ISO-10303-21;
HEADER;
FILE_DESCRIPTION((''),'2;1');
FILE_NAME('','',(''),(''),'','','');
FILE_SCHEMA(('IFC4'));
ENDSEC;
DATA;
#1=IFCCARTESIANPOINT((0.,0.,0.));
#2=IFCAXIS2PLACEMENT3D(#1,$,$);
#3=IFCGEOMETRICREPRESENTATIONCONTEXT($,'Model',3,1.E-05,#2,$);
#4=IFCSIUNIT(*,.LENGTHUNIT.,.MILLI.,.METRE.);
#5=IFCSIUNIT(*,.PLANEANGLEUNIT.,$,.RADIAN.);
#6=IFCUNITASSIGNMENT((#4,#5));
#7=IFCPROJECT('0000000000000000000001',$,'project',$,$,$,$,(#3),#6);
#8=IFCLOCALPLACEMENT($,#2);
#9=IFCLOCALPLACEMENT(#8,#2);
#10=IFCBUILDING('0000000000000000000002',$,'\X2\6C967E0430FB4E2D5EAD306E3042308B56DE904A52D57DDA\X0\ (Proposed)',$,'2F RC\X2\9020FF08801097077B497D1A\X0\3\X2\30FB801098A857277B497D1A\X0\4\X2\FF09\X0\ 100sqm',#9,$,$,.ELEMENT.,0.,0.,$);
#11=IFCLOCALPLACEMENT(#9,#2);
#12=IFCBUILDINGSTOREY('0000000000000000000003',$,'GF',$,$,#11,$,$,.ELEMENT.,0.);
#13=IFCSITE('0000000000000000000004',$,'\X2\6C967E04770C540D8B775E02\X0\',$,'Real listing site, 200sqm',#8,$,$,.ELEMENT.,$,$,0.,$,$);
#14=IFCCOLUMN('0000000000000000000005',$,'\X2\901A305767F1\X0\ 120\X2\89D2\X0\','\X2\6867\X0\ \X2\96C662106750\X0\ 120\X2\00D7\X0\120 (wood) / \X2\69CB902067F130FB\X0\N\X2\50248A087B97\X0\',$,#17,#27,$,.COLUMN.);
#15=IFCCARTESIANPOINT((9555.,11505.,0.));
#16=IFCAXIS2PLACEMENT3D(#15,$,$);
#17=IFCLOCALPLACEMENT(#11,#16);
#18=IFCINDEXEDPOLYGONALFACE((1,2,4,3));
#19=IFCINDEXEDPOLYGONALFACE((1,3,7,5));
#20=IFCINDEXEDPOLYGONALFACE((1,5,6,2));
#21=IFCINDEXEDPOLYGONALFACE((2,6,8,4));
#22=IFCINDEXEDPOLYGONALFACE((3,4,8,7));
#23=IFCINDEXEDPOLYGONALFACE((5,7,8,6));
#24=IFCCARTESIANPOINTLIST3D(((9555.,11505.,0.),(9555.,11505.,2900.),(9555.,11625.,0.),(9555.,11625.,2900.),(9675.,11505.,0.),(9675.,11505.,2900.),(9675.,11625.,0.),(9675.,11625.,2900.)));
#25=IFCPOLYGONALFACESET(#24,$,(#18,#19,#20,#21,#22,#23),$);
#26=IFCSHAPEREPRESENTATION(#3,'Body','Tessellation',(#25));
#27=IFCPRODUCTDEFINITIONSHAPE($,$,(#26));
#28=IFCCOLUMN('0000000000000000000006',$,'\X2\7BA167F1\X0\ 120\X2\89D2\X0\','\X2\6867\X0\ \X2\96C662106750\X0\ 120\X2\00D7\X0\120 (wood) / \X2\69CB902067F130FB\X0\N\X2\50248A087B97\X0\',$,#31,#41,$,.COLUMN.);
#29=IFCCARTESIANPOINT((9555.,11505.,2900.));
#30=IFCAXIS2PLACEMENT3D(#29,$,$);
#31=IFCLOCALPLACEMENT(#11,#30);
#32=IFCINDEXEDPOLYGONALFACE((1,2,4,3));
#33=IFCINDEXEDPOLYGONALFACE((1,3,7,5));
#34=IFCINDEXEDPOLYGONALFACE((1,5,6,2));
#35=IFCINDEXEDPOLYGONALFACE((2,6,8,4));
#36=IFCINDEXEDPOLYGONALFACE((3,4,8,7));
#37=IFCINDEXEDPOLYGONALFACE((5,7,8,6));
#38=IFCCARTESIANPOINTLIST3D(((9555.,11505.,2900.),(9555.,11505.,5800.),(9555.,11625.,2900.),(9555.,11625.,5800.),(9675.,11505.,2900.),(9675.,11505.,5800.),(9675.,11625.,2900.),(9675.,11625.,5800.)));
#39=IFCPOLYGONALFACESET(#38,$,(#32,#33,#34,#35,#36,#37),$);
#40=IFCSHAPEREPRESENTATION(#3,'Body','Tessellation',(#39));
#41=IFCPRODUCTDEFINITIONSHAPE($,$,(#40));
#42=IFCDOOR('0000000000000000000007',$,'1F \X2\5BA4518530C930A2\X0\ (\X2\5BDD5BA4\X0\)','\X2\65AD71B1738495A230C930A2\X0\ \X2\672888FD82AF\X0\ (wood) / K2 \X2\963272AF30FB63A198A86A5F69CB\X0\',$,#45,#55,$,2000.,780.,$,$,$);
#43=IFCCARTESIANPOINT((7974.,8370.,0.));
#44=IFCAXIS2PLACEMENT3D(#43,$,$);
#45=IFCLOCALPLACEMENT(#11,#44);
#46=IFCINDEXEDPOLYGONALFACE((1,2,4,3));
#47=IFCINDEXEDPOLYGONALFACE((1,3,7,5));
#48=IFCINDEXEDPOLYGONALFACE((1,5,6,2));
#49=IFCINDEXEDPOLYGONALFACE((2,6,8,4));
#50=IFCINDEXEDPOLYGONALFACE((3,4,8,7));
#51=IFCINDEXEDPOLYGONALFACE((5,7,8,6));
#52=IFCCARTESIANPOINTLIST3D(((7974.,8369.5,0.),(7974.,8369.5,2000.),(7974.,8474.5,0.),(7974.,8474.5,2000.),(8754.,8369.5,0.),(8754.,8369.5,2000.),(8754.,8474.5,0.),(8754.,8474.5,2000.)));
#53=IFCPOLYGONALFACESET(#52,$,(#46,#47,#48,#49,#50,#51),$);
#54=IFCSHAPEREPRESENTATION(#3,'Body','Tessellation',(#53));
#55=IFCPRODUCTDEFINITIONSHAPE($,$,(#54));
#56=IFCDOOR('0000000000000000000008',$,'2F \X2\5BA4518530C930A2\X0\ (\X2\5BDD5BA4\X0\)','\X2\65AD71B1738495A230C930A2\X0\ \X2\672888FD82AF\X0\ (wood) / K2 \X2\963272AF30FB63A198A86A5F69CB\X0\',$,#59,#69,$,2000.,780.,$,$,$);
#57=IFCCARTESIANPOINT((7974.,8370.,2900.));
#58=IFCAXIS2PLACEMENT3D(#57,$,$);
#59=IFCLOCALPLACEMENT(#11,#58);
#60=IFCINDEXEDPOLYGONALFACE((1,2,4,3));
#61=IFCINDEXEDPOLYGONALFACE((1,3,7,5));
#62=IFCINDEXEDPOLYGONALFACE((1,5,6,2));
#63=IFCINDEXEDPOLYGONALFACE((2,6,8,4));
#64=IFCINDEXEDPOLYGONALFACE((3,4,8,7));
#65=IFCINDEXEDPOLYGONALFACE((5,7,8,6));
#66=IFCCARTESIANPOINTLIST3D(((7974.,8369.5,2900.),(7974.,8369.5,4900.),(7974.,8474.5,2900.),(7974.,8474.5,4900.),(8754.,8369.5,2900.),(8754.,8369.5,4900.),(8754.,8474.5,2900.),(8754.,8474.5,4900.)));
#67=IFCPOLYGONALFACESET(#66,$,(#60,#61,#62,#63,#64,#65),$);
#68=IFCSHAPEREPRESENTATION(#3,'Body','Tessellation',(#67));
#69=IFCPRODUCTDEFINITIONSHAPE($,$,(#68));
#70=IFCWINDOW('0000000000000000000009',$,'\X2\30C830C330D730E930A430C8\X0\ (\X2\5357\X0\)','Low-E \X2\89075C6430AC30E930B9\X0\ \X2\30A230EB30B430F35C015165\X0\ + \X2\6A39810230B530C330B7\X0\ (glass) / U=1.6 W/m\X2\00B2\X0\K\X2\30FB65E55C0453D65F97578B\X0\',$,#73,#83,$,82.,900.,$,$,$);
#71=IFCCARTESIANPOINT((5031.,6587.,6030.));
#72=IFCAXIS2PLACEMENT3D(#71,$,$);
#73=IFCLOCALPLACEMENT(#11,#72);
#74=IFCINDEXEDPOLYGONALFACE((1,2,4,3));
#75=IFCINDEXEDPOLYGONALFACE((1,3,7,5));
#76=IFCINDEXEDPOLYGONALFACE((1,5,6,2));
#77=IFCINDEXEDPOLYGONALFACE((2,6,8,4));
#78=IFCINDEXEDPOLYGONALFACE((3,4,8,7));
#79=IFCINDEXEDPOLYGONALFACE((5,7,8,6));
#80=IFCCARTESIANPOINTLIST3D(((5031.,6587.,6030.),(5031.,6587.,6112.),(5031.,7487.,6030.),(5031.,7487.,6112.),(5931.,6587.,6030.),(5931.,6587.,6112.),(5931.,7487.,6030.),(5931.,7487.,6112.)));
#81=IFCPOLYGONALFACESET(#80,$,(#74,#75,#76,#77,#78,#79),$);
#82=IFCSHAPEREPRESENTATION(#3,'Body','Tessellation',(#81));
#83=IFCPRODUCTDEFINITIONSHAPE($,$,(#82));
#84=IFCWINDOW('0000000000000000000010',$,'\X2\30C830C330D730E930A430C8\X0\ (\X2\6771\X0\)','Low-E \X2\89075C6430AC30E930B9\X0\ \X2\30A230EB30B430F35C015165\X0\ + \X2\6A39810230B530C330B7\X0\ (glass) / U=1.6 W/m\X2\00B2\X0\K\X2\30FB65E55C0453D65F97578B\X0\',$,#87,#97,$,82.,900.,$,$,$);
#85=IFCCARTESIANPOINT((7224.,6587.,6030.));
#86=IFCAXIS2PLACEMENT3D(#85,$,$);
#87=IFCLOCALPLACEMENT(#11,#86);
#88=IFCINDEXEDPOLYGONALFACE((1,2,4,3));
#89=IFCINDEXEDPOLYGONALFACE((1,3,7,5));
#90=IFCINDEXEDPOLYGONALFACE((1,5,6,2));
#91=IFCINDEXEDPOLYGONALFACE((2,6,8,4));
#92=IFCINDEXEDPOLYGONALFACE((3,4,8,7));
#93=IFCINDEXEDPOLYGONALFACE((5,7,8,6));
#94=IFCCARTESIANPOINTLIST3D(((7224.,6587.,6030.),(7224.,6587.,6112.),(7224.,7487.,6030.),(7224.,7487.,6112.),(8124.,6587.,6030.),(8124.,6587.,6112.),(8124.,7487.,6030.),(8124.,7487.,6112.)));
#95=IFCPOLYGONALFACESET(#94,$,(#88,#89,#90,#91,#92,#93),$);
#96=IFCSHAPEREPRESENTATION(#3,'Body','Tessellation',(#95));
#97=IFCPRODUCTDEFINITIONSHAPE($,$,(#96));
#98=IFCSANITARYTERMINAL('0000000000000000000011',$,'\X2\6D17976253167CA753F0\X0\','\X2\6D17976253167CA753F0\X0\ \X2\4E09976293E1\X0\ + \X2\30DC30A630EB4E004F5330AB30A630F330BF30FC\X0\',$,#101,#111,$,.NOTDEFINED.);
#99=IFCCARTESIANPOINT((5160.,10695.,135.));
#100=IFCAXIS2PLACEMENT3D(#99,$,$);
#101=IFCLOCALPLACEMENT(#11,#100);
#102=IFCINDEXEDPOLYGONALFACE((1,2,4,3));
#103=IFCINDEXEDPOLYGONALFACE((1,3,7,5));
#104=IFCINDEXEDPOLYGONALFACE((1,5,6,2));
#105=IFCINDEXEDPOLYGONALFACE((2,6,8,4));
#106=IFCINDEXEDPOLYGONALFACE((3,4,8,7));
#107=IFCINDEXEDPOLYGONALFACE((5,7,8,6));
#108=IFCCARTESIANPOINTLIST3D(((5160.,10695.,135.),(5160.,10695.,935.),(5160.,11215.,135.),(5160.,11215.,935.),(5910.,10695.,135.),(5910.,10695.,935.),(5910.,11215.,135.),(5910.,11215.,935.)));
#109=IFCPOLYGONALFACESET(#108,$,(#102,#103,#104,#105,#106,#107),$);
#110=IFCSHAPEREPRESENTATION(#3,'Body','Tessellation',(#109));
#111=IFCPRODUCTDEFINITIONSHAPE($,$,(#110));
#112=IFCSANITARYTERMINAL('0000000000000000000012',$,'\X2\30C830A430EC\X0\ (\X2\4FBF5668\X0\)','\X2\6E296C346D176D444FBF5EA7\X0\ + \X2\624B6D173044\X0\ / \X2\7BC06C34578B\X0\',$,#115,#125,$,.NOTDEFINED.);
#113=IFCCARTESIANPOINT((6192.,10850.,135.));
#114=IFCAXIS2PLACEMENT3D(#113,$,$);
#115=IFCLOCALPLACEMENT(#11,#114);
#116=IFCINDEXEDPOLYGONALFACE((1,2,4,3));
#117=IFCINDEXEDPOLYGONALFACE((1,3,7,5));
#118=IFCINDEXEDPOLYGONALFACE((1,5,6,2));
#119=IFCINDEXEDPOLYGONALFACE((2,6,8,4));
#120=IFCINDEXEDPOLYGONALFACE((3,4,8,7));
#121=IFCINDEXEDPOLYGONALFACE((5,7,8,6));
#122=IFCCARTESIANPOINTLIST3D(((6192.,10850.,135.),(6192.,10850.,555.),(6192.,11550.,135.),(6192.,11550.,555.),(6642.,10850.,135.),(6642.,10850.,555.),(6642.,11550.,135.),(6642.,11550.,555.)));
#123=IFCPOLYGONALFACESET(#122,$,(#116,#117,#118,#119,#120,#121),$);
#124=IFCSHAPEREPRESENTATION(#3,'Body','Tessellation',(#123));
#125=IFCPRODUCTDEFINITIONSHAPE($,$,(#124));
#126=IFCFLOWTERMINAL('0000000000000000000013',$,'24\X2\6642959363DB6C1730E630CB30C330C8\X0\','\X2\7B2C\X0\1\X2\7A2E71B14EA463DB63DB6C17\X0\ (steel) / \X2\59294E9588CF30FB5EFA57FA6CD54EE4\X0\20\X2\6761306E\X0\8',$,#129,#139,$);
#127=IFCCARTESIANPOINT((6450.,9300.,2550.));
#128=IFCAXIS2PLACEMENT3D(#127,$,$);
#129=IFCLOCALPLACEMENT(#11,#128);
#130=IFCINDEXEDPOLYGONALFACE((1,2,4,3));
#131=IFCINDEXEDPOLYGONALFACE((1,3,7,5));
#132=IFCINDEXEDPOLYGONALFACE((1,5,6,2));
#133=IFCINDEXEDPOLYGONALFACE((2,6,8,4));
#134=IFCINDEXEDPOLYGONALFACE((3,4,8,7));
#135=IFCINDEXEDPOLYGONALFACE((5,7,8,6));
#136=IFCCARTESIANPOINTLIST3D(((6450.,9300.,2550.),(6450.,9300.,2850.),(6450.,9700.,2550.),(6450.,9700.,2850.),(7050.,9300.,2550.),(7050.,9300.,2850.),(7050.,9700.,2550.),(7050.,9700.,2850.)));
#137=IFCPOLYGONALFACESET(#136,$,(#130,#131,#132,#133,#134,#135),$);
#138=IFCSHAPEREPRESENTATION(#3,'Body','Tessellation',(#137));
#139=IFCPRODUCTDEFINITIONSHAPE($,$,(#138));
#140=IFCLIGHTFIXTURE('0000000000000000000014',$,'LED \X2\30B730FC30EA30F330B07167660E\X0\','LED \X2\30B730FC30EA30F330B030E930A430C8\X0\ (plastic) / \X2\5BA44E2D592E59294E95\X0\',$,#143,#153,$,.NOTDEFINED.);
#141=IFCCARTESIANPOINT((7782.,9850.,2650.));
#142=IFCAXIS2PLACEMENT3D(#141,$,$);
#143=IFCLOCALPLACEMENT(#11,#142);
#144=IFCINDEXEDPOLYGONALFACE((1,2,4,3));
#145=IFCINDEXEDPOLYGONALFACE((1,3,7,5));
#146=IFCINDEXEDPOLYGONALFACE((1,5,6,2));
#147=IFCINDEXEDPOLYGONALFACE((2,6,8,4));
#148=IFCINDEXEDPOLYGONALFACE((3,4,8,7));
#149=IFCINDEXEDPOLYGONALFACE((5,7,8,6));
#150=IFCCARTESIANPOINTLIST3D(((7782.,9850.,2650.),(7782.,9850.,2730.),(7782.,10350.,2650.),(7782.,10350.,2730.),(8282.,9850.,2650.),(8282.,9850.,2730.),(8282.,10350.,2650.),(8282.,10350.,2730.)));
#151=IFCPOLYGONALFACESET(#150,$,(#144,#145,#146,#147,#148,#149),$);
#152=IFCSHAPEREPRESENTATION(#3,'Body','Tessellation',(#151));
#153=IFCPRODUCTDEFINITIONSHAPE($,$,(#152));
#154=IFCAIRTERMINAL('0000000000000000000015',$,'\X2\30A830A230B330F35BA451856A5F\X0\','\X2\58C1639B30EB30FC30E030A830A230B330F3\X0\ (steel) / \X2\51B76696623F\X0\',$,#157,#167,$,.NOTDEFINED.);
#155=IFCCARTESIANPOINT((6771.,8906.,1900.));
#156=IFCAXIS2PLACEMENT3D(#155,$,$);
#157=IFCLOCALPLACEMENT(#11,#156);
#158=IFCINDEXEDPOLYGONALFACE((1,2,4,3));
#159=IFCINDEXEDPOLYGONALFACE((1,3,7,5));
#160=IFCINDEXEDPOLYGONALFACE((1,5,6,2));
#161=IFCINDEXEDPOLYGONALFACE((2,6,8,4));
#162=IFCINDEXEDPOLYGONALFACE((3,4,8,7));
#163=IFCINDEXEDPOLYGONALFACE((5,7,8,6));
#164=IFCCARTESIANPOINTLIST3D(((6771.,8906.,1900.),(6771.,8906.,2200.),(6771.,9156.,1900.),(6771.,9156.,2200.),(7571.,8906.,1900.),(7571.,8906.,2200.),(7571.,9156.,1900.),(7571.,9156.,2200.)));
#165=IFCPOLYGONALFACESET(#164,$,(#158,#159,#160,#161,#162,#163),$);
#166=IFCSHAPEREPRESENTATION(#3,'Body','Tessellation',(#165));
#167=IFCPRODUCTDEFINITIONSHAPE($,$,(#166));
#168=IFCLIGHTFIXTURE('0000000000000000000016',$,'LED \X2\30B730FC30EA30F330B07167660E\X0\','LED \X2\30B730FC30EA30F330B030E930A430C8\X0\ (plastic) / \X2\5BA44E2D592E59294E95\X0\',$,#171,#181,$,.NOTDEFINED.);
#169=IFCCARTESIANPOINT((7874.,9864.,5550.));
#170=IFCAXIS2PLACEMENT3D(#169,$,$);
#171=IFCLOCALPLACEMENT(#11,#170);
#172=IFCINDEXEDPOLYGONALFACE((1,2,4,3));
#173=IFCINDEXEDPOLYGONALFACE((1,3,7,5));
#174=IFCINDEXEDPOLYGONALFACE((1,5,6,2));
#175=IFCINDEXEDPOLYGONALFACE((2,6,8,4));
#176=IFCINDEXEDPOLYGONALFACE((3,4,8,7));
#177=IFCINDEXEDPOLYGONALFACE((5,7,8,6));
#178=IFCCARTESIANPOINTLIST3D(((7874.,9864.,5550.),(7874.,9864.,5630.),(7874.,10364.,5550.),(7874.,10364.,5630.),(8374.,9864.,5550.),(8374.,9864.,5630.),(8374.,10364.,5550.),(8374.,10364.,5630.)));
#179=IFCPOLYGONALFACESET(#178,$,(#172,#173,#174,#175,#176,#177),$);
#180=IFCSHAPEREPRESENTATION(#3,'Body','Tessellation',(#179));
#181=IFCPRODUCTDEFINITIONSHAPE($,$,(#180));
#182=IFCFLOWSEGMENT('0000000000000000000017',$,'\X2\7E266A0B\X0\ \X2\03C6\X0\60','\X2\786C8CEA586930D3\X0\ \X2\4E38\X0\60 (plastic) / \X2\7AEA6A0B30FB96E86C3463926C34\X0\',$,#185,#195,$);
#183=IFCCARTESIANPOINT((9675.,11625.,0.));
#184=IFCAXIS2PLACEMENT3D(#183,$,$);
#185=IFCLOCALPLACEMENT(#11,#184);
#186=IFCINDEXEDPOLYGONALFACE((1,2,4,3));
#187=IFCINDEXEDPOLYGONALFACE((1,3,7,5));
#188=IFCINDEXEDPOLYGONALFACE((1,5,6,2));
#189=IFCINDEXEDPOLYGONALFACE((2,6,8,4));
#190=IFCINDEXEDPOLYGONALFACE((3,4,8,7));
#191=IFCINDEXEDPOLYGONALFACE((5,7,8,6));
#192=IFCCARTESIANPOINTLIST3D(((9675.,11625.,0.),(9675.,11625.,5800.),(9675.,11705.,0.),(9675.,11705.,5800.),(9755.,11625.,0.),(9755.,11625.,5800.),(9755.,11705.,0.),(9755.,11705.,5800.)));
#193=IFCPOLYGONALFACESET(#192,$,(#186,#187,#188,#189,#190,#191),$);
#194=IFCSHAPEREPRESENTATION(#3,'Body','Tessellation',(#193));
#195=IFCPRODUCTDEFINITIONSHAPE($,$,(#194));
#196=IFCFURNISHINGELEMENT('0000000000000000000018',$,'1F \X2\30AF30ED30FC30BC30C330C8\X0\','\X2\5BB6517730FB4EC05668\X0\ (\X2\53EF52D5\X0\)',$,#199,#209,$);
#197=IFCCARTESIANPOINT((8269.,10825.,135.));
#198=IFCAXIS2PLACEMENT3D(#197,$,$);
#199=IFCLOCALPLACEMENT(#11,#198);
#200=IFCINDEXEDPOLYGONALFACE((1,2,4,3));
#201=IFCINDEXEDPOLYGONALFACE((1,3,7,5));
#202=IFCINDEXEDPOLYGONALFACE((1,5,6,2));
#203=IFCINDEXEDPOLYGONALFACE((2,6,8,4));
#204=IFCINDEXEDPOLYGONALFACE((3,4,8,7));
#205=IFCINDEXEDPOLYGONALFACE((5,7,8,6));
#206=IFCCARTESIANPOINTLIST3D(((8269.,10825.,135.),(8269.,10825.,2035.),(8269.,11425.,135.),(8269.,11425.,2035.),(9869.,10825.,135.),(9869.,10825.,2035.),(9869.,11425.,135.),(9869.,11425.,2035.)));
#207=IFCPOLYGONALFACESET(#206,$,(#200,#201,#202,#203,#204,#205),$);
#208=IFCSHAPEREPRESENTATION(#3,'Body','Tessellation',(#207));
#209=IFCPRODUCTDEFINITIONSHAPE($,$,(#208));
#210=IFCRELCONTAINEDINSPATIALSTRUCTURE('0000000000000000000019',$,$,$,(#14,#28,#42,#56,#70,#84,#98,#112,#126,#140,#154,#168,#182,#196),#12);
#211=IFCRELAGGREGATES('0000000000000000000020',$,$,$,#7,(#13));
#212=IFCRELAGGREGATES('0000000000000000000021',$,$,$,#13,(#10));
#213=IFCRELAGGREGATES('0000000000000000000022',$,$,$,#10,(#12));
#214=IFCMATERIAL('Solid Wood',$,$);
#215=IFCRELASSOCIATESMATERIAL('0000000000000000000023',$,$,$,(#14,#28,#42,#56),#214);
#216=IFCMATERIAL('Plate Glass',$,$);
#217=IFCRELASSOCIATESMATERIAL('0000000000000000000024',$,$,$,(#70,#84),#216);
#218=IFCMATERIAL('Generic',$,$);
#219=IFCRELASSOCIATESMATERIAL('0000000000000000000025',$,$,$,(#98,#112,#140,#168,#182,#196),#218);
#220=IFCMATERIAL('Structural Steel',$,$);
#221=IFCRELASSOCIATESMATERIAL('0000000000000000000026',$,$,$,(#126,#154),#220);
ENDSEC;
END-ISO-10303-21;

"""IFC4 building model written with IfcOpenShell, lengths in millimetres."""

from ifc_helpers import new_model, si_unit, frame, frame_2d, origin, place, context, project, spatial, rectangle, extrude, material, element, save


model = new_model("IFC4")

# Units and contexts
model_context = context("Model", 3, precision=1e-05, world=origin())
ifc_project = project(units=[si_unit("LENGTHUNIT", "METRE", prefix="MILLI"), si_unit("PLANEANGLEUNIT", "RADIAN")], contexts=[model_context])

# Site, building, storey
site_placement = place(None, origin())
site = spatial("IfcSite", under=ifc_project, at=site_placement, Name="沖縄県名護市", ObjectType="Real listing site, 200sqm", CompositionType="ELEMENT", RefElevation=0.0)
building_placement = place(site_placement, origin())
building = spatial("IfcBuilding", under=site, at=building_placement, Name="沖縄・中庭のある回遊動線 (Proposed)", ObjectType="2F RC造（耐震等級3・耐風圧等級4） 100sqm", CompositionType="ELEMENT", ElevationOfRefHeight=0.0, ElevationOfTerrain=0.0)
storey_placement = place(building_placement, origin())
storey = spatial("IfcBuildingStorey", under=building, at=storey_placement, Name="GF", CompositionType="ELEMENT", Elevation=0.0)

# Columns
ifc_material_1 = material(Name="Solid Wood")
column_1_placement = place(storey_placement, frame((9555.0, 11505.0, 0.0)))
element("IfcColumn", 1, at=column_1_placement, inside=storey, material=ifc_material_1, Name="通し柱 120角", Description="桧 集成材 120×120 (wood) / 構造柱・N値計算", PredefinedType="COLUMN", context=model_context, shape_type="SweptSolid", body=[
    extrude(rectangle(XDim=120.0, YDim=120.0, at=frame_2d((60.0, 60.0))), frame((9555.0, 11505.0, 0.0)), (0.0, 0.0, 1.0), 2900.0),
])
column_2_placement = place(storey_placement, frame((9555.0, 11505.0, 2900.0)))
element("IfcColumn", 2, at=column_2_placement, inside=storey, material=ifc_material_1, Name="管柱 120角", Description="桧 集成材 120×120 (wood) / 構造柱・N値計算", PredefinedType="COLUMN", context=model_context, shape_type="SweptSolid", body=[
    extrude(rectangle(XDim=120.0, YDim=120.0, at=frame_2d((60.0, 60.0))), frame((9555.0, 11505.0, 2900.0)), (0.0, 0.0, 1.0), 2900.0),
])

# Door
door_1_placement = place(storey_placement, frame((7974.0, 8370.0, 0.0)))
element("IfcDoor", 3, at=door_1_placement, inside=storey, material=ifc_material_1, Name="1F 室内ドア (寝室)", Description="断熱玄関ドア 木製芯 (wood) / K2 防犯・採風機構", OverallHeight=2000.0, OverallWidth=780.0, context=model_context, shape_type="SweptSolid", body=[
    extrude(rectangle(XDim=780.0, YDim=105.0, at=frame_2d((390.0, 52.0))), frame((7974.0, 8370.0, 0.0)), (0.0, 0.0, 1.0), 2000.0),
])

# Door
door_2_placement = place(storey_placement, frame((7974.0, 8370.0, 2900.0)))
element("IfcDoor", 4, at=door_2_placement, inside=storey, material=ifc_material_1, Name="2F 室内ドア (寝室)", Description="断熱玄関ドア 木製芯 (wood) / K2 防犯・採風機構", OverallHeight=2000.0, OverallWidth=780.0, context=model_context, shape_type="SweptSolid", body=[
    extrude(rectangle(XDim=780.0, YDim=105.0, at=frame_2d((390.0, 52.0))), frame((7974.0, 8370.0, 2900.0)), (0.0, 0.0, 1.0), 2000.0),
])

# Windows
ifc_material_2 = material(Name="Plate Glass")
window_1_placement = place(storey_placement, frame((5031.0, 6587.0, 6030.0)))
element("IfcWindow", 5, at=window_1_placement, inside=storey, material=ifc_material_2, Name="トップライト (南)", Description="Low-E 複層ガラス アルゴン封入 + 樹脂サッシ (glass) / U=1.6 W/m²K・日射取得型", OverallHeight=82.0, OverallWidth=900.0, context=model_context, shape_type="SweptSolid", body=[
    extrude(rectangle(XDim=900.0, YDim=900.0, at=frame_2d((450.0, 450.0))), frame((5031.0, 6587.0, 6030.0)), (0.0, 0.0, 1.0), 82.0),
])
window_2_placement = place(storey_placement, frame((7224.0, 6587.0, 6030.0)))
element("IfcWindow", 6, at=window_2_placement, inside=storey, material=ifc_material_2, Name="トップライト (東)", Description="Low-E 複層ガラス アルゴン封入 + 樹脂サッシ (glass) / U=1.6 W/m²K・日射取得型", OverallHeight=82.0, OverallWidth=900.0, context=model_context, shape_type="SweptSolid", body=[
    extrude(rectangle(XDim=900.0, YDim=900.0, at=frame_2d((450.0, 450.0))), frame((7224.0, 6587.0, 6030.0)), (0.0, 0.0, 1.0), 82.0),
])

# Sanitary terminals
ifc_material_3 = material(Name="Generic")
sanitary_terminal_1_placement = place(storey_placement, frame((5160.0, 10695.0, 135.0)))
element("IfcSanitaryTerminal", 7, at=sanitary_terminal_1_placement, inside=storey, material=ifc_material_3, Name="洗面化粧台", Description="洗面化粧台 三面鏡 + ボウル一体カウンター", PredefinedType="NOTDEFINED", context=model_context, shape_type="SweptSolid", body=[
    extrude(rectangle(XDim=750.0, YDim=520.0, at=frame_2d((375.0, 260.0))), frame((5160.0, 10695.0, 135.0)), (0.0, 0.0, 1.0), 800.0),
])
sanitary_terminal_2_placement = place(storey_placement, frame((6192.0, 10850.0, 135.0)))
element("IfcSanitaryTerminal", 8, at=sanitary_terminal_2_placement, inside=storey, material=ifc_material_3, Name="トイレ (便器)", Description="温水洗浄便座 + 手洗い / 節水型", PredefinedType="NOTDEFINED", context=model_context, shape_type="SweptSolid", body=[
    extrude(rectangle(XDim=450.0, YDim=700.0, at=frame_2d((225.0, 350.0))), frame((6192.0, 10850.0, 135.0)), (0.0, 0.0, 1.0), 420.0),
])

# Flow terminal
ifc_material_4 = material(Name="Structural Steel")
flow_terminal_placement = place(storey_placement, frame((6450.0, 9300.0, 2550.0)))
element("IfcFlowTerminal", 9, at=flow_terminal_placement, inside=storey, material=ifc_material_4, Name="24時間換気ユニット", Description="第1種熱交換換気 (steel) / 天井裏・建基法令20条の8", context=model_context, shape_type="SweptSolid", body=[
    extrude(rectangle(XDim=600.0, YDim=400.0, at=frame_2d((300.0, 200.0))), frame((6450.0, 9300.0, 2550.0)), (0.0, 0.0, 1.0), 300.0),
])

# Light fixture
light_fixture_1_placement = place(storey_placement, frame((7782.0, 9850.0, 2650.0)))
element("IfcLightFixture", 10, at=light_fixture_1_placement, inside=storey, material=ifc_material_3, Name="LED シーリング照明", Description="LED シーリングライト (plastic) / 室中央天井", PredefinedType="NOTDEFINED", context=model_context, shape_type="SweptSolid", body=[
    extrude(rectangle(XDim=500.0, YDim=500.0, at=frame_2d((250.0, 250.0))), frame((7782.0, 9850.0, 2650.0)), (0.0, 0.0, 1.0), 80.0),
])

# Air terminal
air_terminal_placement = place(storey_placement, frame((6771.0, 8906.0, 1900.0)))
element("IfcAirTerminal", 11, at=air_terminal_placement, inside=storey, material=ifc_material_4, Name="エアコン室内機", Description="壁掛ルームエアコン (steel) / 冷暖房", PredefinedType="NOTDEFINED", context=model_context, shape_type="SweptSolid", body=[
    extrude(rectangle(XDim=800.0, YDim=250.0, at=frame_2d((400.0, 125.0))), frame((6771.0, 8906.0, 1900.0)), (0.0, 0.0, 1.0), 300.0),
])

# Light fixture
light_fixture_2_placement = place(storey_placement, frame((7874.0, 9864.0, 5550.0)))
element("IfcLightFixture", 12, at=light_fixture_2_placement, inside=storey, material=ifc_material_3, Name="LED シーリング照明", Description="LED シーリングライト (plastic) / 室中央天井", PredefinedType="NOTDEFINED", context=model_context, shape_type="SweptSolid", body=[
    extrude(rectangle(XDim=500.0, YDim=500.0, at=frame_2d((250.0, 250.0))), frame((7874.0, 9864.0, 5550.0)), (0.0, 0.0, 1.0), 80.0),
])

# Flow segment
flow_segment_placement = place(storey_placement, frame((9675.0, 11625.0, 0.0)))
element("IfcFlowSegment", 13, at=flow_segment_placement, inside=storey, material=ifc_material_3, Name="縦樋 φ60", Description="硬質塩ビ 丸60 (plastic) / 竪樋・雨水排水", context=model_context, shape_type="SweptSolid", body=[
    extrude(rectangle(XDim=80.0, YDim=80.0, at=frame_2d((40.0, 40.0))), frame((9675.0, 11625.0, 0.0)), (0.0, 0.0, 1.0), 5800.0),
])

# Furnishing element
furnishing_1_placement = place(storey_placement, frame((8269.0, 10825.0, 135.0)))
element("IfcFurnishingElement", 14, at=furnishing_1_placement, inside=storey, material=ifc_material_3, Name="1F クローゼット", Description="家具・什器 (可動)", context=model_context, shape_type="SweptSolid", body=[
    extrude(rectangle(XDim=1600.0, YDim=600.0, at=frame_2d((800.0, 300.0))), frame((8269.0, 10825.0, 135.0)), (0.0, 0.0, 1.0), 1900.0),
])

save(model, "model.ifc")
